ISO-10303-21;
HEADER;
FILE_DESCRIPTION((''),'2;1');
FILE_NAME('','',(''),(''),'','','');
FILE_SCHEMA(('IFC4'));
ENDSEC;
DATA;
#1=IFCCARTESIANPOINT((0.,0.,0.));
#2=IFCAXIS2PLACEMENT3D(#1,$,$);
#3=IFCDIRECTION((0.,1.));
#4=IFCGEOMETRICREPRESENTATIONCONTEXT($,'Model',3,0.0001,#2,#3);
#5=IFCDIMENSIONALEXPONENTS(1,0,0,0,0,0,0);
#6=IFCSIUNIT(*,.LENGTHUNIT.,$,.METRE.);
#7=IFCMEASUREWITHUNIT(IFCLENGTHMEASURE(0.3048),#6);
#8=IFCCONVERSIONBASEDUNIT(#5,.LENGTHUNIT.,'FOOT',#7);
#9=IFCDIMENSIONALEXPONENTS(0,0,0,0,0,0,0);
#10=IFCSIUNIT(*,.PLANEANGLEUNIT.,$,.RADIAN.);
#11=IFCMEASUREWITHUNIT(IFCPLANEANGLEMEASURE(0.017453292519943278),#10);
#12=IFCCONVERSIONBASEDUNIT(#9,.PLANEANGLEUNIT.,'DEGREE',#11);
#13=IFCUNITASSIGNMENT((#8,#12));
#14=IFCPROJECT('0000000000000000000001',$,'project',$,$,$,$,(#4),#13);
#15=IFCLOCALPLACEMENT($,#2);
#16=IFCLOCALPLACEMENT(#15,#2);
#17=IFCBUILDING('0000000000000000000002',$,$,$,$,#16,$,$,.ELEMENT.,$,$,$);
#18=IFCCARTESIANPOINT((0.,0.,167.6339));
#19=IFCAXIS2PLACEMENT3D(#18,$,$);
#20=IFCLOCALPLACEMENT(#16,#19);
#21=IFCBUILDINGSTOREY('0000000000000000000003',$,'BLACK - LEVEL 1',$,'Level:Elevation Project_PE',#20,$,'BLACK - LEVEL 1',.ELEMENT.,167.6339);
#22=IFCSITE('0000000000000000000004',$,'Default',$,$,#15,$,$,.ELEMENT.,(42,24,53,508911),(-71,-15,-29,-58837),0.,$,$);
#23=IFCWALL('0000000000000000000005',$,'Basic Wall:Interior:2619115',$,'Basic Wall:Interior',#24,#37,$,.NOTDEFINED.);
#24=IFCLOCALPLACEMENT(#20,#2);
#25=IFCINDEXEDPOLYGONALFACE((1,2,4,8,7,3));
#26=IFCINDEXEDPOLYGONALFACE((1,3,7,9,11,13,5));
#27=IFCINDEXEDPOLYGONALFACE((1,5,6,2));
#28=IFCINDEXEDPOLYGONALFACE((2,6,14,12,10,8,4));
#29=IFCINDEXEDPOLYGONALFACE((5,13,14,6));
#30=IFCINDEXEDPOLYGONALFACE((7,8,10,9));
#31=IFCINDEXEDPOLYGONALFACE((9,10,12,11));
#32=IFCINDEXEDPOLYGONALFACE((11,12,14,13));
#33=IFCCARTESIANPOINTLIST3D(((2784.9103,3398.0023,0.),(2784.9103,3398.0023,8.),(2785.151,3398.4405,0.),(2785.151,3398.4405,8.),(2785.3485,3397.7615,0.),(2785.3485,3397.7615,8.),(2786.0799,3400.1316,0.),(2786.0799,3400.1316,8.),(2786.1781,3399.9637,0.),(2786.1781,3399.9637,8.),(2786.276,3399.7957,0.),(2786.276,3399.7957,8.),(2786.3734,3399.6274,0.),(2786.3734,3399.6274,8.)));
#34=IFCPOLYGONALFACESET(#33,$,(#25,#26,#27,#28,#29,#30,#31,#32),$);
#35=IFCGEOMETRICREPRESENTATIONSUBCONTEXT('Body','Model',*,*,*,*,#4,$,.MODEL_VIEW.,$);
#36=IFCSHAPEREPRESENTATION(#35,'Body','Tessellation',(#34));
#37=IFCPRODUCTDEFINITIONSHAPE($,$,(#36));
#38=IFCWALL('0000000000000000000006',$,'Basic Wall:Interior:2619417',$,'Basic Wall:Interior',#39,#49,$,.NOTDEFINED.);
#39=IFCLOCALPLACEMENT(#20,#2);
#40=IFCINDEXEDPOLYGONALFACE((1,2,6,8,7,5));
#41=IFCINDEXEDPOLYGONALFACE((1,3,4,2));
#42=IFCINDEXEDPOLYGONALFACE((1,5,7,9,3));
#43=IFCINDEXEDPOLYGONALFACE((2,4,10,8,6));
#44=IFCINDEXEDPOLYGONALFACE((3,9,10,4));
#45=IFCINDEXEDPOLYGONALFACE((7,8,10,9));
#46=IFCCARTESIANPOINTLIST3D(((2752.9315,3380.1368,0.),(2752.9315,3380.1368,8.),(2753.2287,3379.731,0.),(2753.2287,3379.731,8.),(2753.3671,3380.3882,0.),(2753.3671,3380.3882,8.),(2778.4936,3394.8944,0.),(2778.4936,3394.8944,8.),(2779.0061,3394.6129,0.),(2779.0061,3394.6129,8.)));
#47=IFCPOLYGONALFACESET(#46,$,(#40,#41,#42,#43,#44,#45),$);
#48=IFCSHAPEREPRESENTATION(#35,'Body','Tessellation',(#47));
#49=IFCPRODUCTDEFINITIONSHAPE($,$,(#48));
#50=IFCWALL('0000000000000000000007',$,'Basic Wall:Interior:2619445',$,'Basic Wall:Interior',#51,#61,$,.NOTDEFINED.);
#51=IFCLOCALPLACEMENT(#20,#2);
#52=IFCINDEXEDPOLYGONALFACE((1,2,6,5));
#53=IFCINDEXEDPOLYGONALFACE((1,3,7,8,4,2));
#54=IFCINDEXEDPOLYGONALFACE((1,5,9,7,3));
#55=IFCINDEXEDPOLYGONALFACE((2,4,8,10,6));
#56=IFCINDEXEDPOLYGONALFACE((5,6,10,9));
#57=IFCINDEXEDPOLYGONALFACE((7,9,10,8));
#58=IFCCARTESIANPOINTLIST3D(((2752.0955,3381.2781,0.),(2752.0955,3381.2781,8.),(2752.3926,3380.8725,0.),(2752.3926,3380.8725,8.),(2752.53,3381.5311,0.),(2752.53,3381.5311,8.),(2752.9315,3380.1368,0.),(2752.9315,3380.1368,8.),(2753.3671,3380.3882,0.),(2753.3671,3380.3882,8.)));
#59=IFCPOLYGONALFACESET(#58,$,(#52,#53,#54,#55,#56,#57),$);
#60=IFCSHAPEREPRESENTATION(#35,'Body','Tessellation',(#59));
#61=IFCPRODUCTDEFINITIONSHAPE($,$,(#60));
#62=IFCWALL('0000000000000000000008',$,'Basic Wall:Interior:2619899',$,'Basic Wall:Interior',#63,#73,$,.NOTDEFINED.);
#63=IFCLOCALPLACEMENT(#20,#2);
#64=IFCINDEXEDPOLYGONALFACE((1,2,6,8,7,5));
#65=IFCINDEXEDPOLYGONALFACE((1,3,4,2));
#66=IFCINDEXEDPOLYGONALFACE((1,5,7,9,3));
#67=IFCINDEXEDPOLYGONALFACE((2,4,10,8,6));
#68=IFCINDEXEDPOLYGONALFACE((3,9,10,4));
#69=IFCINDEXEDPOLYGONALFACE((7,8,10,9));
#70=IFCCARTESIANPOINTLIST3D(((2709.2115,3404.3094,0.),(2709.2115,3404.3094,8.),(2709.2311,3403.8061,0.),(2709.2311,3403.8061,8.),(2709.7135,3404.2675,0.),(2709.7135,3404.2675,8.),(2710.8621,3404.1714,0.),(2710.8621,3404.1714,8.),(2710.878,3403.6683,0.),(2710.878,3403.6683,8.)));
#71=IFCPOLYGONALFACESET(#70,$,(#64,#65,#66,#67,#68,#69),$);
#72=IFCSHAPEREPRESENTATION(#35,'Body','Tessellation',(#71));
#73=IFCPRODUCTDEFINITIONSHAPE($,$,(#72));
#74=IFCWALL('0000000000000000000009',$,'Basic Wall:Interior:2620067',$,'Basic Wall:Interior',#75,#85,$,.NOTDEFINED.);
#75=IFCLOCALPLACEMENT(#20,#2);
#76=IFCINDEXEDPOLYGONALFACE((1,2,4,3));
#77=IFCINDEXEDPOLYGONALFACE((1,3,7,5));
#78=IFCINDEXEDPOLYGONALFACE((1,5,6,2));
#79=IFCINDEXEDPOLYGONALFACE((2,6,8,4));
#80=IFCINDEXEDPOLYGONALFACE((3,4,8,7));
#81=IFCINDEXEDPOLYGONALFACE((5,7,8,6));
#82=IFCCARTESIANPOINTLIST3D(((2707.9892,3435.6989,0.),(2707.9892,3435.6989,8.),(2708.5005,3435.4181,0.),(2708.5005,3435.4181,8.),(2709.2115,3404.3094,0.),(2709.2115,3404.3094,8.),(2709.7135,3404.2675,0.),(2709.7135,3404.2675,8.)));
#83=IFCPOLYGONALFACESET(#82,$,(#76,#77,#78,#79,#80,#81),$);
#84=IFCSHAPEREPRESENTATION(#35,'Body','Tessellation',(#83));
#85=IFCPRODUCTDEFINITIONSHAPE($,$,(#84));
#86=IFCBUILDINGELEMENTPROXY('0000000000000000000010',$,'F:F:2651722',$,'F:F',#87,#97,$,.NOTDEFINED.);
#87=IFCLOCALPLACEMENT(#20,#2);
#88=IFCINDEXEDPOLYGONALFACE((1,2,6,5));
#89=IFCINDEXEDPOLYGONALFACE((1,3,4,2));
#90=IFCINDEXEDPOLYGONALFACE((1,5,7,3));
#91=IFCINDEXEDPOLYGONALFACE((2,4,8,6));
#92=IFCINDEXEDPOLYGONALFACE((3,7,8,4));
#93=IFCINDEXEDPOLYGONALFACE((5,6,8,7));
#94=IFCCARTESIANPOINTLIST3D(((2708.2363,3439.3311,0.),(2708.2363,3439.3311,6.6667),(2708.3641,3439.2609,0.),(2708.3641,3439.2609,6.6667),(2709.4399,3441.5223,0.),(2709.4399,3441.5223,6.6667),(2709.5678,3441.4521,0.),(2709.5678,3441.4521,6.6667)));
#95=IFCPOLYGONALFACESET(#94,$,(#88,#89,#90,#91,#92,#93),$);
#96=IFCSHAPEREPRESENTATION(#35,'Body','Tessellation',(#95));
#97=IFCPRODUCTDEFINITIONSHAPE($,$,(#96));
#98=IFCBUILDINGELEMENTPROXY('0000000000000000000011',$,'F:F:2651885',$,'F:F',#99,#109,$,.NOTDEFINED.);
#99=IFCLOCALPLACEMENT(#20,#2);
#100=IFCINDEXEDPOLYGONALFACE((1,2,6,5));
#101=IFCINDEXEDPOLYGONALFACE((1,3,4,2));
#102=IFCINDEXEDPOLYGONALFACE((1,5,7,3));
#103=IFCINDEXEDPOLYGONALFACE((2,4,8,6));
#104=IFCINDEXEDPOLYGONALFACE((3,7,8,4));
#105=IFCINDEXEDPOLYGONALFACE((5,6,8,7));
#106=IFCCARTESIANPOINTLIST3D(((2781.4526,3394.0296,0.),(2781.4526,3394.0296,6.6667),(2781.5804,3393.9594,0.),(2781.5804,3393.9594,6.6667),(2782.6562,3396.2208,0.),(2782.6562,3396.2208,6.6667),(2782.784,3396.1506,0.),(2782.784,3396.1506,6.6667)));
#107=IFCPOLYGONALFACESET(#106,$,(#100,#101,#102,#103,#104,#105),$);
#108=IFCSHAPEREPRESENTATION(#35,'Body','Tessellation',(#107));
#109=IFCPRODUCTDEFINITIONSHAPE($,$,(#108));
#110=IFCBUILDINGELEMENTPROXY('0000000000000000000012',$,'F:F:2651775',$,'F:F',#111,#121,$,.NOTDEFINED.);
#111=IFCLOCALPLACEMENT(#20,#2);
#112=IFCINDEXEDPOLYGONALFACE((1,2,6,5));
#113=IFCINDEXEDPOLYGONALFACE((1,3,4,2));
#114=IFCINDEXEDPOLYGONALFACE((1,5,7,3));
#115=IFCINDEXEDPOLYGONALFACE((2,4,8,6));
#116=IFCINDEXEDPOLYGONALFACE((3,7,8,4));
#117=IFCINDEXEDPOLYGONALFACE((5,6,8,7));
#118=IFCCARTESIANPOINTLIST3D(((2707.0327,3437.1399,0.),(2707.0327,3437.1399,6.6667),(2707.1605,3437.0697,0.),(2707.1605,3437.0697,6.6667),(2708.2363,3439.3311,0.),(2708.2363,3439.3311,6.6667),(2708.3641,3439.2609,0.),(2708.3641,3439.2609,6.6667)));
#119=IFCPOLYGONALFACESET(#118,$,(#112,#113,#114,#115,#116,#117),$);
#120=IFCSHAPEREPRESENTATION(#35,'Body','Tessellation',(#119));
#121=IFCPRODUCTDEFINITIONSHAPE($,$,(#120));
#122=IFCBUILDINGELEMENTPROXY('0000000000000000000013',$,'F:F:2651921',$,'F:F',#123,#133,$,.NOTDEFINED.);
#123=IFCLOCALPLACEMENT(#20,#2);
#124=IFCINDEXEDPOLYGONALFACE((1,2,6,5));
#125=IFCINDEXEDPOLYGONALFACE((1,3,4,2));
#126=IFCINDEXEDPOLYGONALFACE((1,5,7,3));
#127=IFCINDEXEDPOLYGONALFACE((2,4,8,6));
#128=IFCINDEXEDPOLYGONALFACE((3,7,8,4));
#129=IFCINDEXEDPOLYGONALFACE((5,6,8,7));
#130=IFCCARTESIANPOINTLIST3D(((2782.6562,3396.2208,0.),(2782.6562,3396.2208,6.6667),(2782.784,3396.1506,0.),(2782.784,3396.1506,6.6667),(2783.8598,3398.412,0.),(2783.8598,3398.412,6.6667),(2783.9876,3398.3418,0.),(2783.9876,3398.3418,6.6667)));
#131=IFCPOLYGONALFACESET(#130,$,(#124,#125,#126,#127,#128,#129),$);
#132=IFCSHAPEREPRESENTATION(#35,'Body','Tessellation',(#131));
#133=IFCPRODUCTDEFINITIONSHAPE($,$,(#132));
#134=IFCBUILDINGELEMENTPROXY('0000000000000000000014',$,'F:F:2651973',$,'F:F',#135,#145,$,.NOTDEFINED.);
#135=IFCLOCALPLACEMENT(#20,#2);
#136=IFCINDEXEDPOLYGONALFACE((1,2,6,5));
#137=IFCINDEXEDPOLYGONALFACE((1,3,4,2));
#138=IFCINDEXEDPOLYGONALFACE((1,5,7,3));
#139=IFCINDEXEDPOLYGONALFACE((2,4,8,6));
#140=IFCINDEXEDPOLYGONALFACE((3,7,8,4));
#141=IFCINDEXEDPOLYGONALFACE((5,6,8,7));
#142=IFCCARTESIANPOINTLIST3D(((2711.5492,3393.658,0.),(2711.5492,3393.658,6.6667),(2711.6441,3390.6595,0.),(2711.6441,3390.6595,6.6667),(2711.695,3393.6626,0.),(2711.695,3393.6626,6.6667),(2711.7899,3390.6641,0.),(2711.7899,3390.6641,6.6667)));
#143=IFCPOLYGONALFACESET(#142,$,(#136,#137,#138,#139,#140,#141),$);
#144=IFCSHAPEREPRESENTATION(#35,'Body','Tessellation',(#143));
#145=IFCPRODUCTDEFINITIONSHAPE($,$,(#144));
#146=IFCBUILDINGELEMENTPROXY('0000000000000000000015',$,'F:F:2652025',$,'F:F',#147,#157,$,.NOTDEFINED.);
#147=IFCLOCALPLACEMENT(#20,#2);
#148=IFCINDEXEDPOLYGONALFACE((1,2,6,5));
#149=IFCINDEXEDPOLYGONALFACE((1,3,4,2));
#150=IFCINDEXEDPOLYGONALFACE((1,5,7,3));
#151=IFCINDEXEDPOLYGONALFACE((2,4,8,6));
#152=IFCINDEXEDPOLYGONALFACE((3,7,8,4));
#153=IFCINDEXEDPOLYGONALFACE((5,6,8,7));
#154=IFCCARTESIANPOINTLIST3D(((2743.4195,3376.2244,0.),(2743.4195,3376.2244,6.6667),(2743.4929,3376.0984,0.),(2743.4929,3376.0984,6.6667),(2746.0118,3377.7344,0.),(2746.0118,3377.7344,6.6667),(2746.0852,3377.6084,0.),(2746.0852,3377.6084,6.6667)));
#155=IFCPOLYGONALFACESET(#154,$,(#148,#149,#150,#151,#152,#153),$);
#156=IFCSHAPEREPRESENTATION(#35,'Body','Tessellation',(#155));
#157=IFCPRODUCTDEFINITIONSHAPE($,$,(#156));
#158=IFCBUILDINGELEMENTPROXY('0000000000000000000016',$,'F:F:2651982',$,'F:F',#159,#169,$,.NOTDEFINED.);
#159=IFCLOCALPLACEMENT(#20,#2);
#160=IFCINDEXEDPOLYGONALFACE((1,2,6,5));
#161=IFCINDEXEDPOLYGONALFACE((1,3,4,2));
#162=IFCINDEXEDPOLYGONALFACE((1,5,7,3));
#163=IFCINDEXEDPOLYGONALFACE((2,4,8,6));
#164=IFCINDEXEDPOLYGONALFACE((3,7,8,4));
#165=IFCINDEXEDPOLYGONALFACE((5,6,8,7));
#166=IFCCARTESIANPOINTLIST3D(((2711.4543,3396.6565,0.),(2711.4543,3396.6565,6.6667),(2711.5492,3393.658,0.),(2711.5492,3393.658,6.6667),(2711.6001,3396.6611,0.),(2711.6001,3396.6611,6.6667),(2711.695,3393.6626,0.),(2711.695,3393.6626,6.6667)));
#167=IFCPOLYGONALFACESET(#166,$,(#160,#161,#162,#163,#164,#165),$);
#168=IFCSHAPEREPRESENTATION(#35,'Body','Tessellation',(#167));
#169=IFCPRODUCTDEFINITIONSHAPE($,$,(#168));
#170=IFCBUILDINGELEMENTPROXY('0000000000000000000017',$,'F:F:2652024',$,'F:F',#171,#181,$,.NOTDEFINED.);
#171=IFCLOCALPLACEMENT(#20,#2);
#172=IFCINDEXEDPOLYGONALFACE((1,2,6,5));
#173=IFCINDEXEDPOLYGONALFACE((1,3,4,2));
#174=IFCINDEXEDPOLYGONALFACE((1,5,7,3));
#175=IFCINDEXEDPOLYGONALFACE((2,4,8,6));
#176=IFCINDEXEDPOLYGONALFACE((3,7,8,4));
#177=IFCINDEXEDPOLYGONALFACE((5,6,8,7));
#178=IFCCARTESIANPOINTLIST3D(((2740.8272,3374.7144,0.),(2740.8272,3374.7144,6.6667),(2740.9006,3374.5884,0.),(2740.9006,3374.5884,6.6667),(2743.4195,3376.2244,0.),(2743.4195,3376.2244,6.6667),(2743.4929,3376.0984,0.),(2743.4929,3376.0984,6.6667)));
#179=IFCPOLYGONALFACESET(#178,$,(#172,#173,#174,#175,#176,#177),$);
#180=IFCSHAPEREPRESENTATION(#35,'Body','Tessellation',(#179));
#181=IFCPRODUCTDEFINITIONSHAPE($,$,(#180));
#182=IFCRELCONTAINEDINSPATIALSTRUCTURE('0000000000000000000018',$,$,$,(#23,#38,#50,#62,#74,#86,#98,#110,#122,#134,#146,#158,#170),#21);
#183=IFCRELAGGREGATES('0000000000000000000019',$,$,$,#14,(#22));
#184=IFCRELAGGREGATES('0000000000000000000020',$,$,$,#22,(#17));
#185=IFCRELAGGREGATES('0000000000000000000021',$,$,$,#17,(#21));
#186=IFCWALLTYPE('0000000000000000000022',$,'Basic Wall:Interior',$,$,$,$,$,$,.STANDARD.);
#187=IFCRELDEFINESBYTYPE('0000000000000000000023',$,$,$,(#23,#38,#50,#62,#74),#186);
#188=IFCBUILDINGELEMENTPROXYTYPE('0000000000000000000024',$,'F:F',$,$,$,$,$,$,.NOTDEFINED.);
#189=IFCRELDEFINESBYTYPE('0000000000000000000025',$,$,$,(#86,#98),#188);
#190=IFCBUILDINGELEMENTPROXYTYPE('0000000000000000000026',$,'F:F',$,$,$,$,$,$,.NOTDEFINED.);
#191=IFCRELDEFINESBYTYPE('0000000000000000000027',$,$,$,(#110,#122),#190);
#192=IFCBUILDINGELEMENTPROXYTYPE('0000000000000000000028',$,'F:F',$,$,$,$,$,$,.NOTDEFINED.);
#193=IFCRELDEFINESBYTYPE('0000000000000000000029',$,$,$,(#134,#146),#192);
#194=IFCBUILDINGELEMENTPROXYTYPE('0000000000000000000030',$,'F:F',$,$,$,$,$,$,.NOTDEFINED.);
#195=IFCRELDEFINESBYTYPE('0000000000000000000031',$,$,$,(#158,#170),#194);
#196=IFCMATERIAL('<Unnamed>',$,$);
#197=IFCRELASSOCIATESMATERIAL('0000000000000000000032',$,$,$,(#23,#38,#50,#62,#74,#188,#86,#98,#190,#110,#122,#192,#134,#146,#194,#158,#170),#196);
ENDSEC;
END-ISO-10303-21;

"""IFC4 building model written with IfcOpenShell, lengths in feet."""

from ifc_helpers import new_model, entity, si_unit, converted_unit, direction, frame, origin, place, context, subcontext, project, spatial, line, arc, indexed_curve, outline, extrude, source, transform, mapped, material, type_object, type_shapes, element, save


model = new_model("IFC4")

# Units and contexts
model_context = context("Model", 3, precision=0.0001, world=origin(), true_north=direction((0.0, 1.0)))
body_context = subcontext(model_context, "Body", "Model", "MODEL_VIEW")
ifc_project = project(units=[converted_unit("LENGTHUNIT", "FOOT", entity("IfcLengthMeasure", 0.3048), si_unit("LENGTHUNIT", "METRE"), dimensions=[1, 0, 0, 0, 0, 0, 0]), converted_unit("PLANEANGLEUNIT", "DEGREE", entity("IfcPlaneAngleMeasure", 0.017453292519943278), si_unit("PLANEANGLEUNIT", "RADIAN"), dimensions=[0, 0, 0, 0, 0, 0, 0])], contexts=[model_context])

# Site, building, storey
site_placement = place(None, origin())
site = spatial("IfcSite", under=ifc_project, at=site_placement, Name="Default", CompositionType="ELEMENT", RefLatitude=(42, 24, 53, 508911), RefLongitude=(-71, -15, -29, -58837), RefElevation=0.0)
building_placement = place(site_placement, origin())
building = spatial("IfcBuilding", under=site, at=building_placement, CompositionType="ELEMENT")
storey_placement = place(building_placement, frame((0.0, 0.0, 167.6339)))
storey = spatial("IfcBuildingStorey", under=building, at=storey_placement, Name="BLACK - LEVEL 1", ObjectType="Level:Elevation Project_PE", LongName="BLACK - LEVEL 1", CompositionType="ELEMENT", Elevation=167.6339)

# Walls
ifc_material_1 = material(Name="<Unnamed>")
wall_type = type_object("IfcWallType", Name="Basic Wall:Interior", PredefinedType="STANDARD")
wall_1_placement = place(storey_placement, frame((2786.299, 3400.0112, 0.0), z_axis=(0.0, 0.0, 1.0), x_axis=(-0.481445, -0.876477, 0.0)))
element("IfcWall", 1, at=wall_1_placement, inside=storey, type_object=wall_type, material=ifc_material_1, Name="Basic Wall:Interior:2619115", ObjectType="Basic Wall:Interior", PredefinedType="NOTDEFINED", context=body_context, shape_type="SweptSolid", body=[
    extrude(outline(indexed_curve([(2.4294, -0.25), (2.4294, 0.25), (0.3006, 0.25), (0.1499, 0.0003), (0.0, -0.25), (1.9294, -0.25)], segments=[line(1, 2, 3), arc(3, 4, 5), line(5, 6, 1)], self_intersect=False)), origin(), (0.0, 0.0, 1.0), 8.0),
])
wall_2_placement = place(storey_placement, frame((2778.8811, 3394.8294, 0.0), z_axis=(0.0, 0.0, 1.0), x_axis=(-0.866036, -0.499982, 0.0)))
element("IfcWall", 2, at=wall_2_placement, inside=storey, type_object=wall_type, material=ifc_material_1, Name="Basic Wall:Interior:2619417", ObjectType="Basic Wall:Interior", PredefinedType="NOTDEFINED", context=body_context, shape_type="SweptSolid", body=[
    extrude(outline(indexed_curve([(29.8193, -0.25), (29.7648, 0.25), (0.0, 0.25), (0.3031, -0.25), (29.3163, -0.25), (29.8193, -0.25)], self_intersect=False)), origin(), (0.0, 0.0, 1.0), 8.0),
])
wall_3_placement = place(storey_placement, frame((2753.1654, 3380.2405, 0.0), z_axis=(0.0, 0.0, 1.0), x_axis=(-0.59089, 0.806752, 0.0)))
element("IfcWall", 3, at=wall_3_placement, inside=storey, type_object=wall_type, material=ifc_material_1, Name="Basic Wall:Interior:2619445", ObjectType="Basic Wall:Interior", PredefinedType="NOTDEFINED", context=body_context, shape_type="SweptSolid", body=[
    extrude(outline(indexed_curve([(1.4167, -0.25), (1.4692, 0.25), (0.9665, 0.25), (0.0545, 0.25), (0.0, -0.25), (1.4167, -0.25)], self_intersect=False)), origin(), (0.0, 0.0, 1.0), 8.0),
])
wall_4_placement = place(storey_placement, frame((2710.8989, 3403.9175, 0.0), z_axis=(0.0, 0.0, 1.0), x_axis=(-0.996522, 0.083326, 0.0)))
element("IfcWall", 4, at=wall_4_placement, inside=storey, type_object=wall_type, material=ifc_material_1, Name="Basic Wall:Interior:2619899", ObjectType="Basic Wall:Interior", PredefinedType="NOTDEFINED", context=body_context, shape_type="SweptSolid", body=[
    extrude(outline(indexed_curve([(1.7142, -0.25), (1.6527, 0.25), (0.0, 0.25), (0.0578, -0.25), (1.2104, -0.25), (1.7142, -0.25)], self_intersect=False)), origin(), (0.0, 0.0, 1.0), 8.0),
])
wall_5_placement = place(storey_placement, frame((2709.4637, 3404.2577, 0.0), z_axis=(0.0, 0.0, 1.0), x_axis=(-0.038909, 0.999243, 0.0)))
element("IfcWall", 5, at=wall_5_placement, inside=storey, type_object=wall_type, material=ifc_material_1, Name="Basic Wall:Interior:2620067", ObjectType="Basic Wall:Interior", PredefinedType="NOTDEFINED", context=body_context, shape_type="SweptSolid", body=[
    extrude(outline(indexed_curve([(31.1742, -0.25), (31.4748, 0.25), (0.0615, 0.25), (0.0, -0.25), (31.1742, -0.25)], self_intersect=False)), origin(), (0.0, 0.0, 1.0), 8.0),
])

# Building element proxies
building_element_proxy_type_1 = type_object("IfcBuildingElementProxyType", Name="F:F", PredefinedType="NOTDEFINED", material=ifc_material_1)
shared_shape_1 = source(origin(), body_context, "Body", "SweptSolid", [
    extrude(outline(indexed_curve([(-0.0729, -1.25), (0.0729, -1.25), (0.0729, 1.25), (-0.0729, 1.25), (-0.0729, -1.25)], self_intersect=False)), frame((-0.2859, 3.25, 0.0), z_axis=(0.0, 0.0, 1.0), x_axis=(0.0, 1.0, 0.0)), (0.0, 0.0, 1.0), 6.6667),
])
type_shapes(building_element_proxy_type_1, [shared_shape_1])
for number, where, z_axis, x_axis, name in (
    (6, (2711.8882, 3439.0775, 0.0), (0.0, 0.0, 1.0), (0.481445, 0.876477, 0.0), "F:F:2651722"),
    (7, (2779.1321, 3396.4042, 0.0), (0.0, 0.0, 1.0), (-0.481445, -0.876477, 0.0), "F:F:2651885"),
):
    element("IfcBuildingElementProxy", number, at=place(storey_placement, frame(where, z_axis=z_axis, x_axis=x_axis)), inside=storey, type_object=building_element_proxy_type_1, material=ifc_material_1, Name=name, ObjectType="F:F", PredefinedType="NOTDEFINED", context=body_context, shape_type="MappedRepresentation", body=[
        mapped(shared_shape_1, transform((0.0, 0.0, 0.0), scale=1.0)),
    ])
building_element_proxy_type_2 = type_object("IfcBuildingElementProxyType", Name="F:F", PredefinedType="NOTDEFINED", material=ifc_material_1)
shared_shape_2 = source(origin(), body_context, "Body", "SweptSolid", [
    extrude(outline(indexed_curve([(-1.25, -0.0729), (1.25, -0.0729), (1.25, 0.0729), (-1.25, 0.0729), (-1.25, -0.0729)], self_intersect=False)), frame((-0.2859, -3.25, 0.0), z_axis=(0.0, 0.0, 1.0), x_axis=(-1.0, 0.0, 0.0)), (0.0, 0.0, 1.0), 6.6667),
])
type_shapes(building_element_proxy_type_2, [shared_shape_2])
for number, where, z_axis, x_axis, name in (
    (8, (2710.4093, 3436.3852, 0.0), (0.0, 0.0, 1.0), (-0.481445, -0.876477, 0.0), "F:F:2651775"),
    (9, (2780.611, 3399.0966, 0.0), (0.0, 0.0, 1.0), (0.481445, 0.876477, 0.0), "F:F:2651921"),
):
    element("IfcBuildingElementProxy", number, at=place(storey_placement, frame(where, z_axis=z_axis, x_axis=x_axis)), inside=storey, type_object=building_element_proxy_type_2, material=ifc_material_1, Name=name, ObjectType="F:F", PredefinedType="NOTDEFINED", context=body_context, shape_type="MappedRepresentation", body=[
        mapped(shared_shape_2, transform((0.0, 0.0, 0.0), scale=1.0)),
    ])
building_element_proxy_type_3 = type_object("IfcBuildingElementProxyType", Name="F:F", PredefinedType="NOTDEFINED", material=ifc_material_1)
shared_shape_3 = source(origin(), body_context, "Body", "SweptSolid", [
    extrude(outline(indexed_curve([(-0.0729, -1.5), (0.0729, -1.5), (0.0729, 1.5), (-0.0729, 1.5), (-0.0729, -1.5)], self_intersect=False)), frame((-0.2859, 3.25, 0.0), z_axis=(0.0, 0.0, 1.0), x_axis=(0.0, 1.0, 0.0)), (0.0, 0.0, 1.0), 6.6667),
])
type_shapes(building_element_proxy_type_3, [shared_shape_3])
for number, where, z_axis, x_axis, name in (
    (10, (2708.4302, 3391.7725, 0.0), (0.0, 0.0, 1.0), (0.031634, -0.9995, 0.0), "F:F:2651973"),
    (11, (2746.6352, 3374.252, 0.0), (0.0, 0.0, 1.0), (0.864097, 0.503325, 0.0), "F:F:2652025"),
):
    element("IfcBuildingElementProxy", number, at=place(storey_placement, frame(where, z_axis=z_axis, x_axis=x_axis)), inside=storey, type_object=building_element_proxy_type_3, material=ifc_material_1, Name=name, ObjectType="F:F", PredefinedType="NOTDEFINED", context=body_context, shape_type="MappedRepresentation", body=[
        mapped(shared_shape_3, transform((0.0, 0.0, 0.0), scale=1.0)),
    ])
building_element_proxy_type_4 = type_object("IfcBuildingElementProxyType", Name="F:F", PredefinedType="NOTDEFINED", material=ifc_material_1)
shared_shape_4 = source(origin(), body_context, "Body", "SweptSolid", [
    extrude(outline(indexed_curve([(-1.5, -0.0729), (1.5, -0.0729), (1.5, 0.0729), (-1.5, 0.0729), (-1.5, -0.0729)], self_intersect=False)), frame((-0.2859, -3.25, 0.0), z_axis=(0.0, 0.0, 1.0), x_axis=(-1.0, 0.0, 0.0)), (0.0, 0.0, 1.0), 6.6667),
])
type_shapes(building_element_proxy_type_4, [shared_shape_4])
for number, where, z_axis, x_axis, name in (
    (12, (2708.3172, 3395.3424, 0.0), (0.0, 0.0, 1.0), (-0.031634, 0.9995, 0.0), "F:F:2651982"),
    (13, (2743.5488, 3372.4542, 0.0), (0.0, 0.0, 1.0), (-0.864097, -0.503325, 0.0), "F:F:2652024"),
):
    element("IfcBuildingElementProxy", number, at=place(storey_placement, frame(where, z_axis=z_axis, x_axis=x_axis)), inside=storey, type_object=building_element_proxy_type_4, material=ifc_material_1, Name=name, ObjectType="F:F", PredefinedType="NOTDEFINED", context=body_context, shape_type="MappedRepresentation", body=[
        mapped(shared_shape_4, transform((0.0, 0.0, 0.0), scale=1.0)),
    ])

save(model, "model.ifc")
